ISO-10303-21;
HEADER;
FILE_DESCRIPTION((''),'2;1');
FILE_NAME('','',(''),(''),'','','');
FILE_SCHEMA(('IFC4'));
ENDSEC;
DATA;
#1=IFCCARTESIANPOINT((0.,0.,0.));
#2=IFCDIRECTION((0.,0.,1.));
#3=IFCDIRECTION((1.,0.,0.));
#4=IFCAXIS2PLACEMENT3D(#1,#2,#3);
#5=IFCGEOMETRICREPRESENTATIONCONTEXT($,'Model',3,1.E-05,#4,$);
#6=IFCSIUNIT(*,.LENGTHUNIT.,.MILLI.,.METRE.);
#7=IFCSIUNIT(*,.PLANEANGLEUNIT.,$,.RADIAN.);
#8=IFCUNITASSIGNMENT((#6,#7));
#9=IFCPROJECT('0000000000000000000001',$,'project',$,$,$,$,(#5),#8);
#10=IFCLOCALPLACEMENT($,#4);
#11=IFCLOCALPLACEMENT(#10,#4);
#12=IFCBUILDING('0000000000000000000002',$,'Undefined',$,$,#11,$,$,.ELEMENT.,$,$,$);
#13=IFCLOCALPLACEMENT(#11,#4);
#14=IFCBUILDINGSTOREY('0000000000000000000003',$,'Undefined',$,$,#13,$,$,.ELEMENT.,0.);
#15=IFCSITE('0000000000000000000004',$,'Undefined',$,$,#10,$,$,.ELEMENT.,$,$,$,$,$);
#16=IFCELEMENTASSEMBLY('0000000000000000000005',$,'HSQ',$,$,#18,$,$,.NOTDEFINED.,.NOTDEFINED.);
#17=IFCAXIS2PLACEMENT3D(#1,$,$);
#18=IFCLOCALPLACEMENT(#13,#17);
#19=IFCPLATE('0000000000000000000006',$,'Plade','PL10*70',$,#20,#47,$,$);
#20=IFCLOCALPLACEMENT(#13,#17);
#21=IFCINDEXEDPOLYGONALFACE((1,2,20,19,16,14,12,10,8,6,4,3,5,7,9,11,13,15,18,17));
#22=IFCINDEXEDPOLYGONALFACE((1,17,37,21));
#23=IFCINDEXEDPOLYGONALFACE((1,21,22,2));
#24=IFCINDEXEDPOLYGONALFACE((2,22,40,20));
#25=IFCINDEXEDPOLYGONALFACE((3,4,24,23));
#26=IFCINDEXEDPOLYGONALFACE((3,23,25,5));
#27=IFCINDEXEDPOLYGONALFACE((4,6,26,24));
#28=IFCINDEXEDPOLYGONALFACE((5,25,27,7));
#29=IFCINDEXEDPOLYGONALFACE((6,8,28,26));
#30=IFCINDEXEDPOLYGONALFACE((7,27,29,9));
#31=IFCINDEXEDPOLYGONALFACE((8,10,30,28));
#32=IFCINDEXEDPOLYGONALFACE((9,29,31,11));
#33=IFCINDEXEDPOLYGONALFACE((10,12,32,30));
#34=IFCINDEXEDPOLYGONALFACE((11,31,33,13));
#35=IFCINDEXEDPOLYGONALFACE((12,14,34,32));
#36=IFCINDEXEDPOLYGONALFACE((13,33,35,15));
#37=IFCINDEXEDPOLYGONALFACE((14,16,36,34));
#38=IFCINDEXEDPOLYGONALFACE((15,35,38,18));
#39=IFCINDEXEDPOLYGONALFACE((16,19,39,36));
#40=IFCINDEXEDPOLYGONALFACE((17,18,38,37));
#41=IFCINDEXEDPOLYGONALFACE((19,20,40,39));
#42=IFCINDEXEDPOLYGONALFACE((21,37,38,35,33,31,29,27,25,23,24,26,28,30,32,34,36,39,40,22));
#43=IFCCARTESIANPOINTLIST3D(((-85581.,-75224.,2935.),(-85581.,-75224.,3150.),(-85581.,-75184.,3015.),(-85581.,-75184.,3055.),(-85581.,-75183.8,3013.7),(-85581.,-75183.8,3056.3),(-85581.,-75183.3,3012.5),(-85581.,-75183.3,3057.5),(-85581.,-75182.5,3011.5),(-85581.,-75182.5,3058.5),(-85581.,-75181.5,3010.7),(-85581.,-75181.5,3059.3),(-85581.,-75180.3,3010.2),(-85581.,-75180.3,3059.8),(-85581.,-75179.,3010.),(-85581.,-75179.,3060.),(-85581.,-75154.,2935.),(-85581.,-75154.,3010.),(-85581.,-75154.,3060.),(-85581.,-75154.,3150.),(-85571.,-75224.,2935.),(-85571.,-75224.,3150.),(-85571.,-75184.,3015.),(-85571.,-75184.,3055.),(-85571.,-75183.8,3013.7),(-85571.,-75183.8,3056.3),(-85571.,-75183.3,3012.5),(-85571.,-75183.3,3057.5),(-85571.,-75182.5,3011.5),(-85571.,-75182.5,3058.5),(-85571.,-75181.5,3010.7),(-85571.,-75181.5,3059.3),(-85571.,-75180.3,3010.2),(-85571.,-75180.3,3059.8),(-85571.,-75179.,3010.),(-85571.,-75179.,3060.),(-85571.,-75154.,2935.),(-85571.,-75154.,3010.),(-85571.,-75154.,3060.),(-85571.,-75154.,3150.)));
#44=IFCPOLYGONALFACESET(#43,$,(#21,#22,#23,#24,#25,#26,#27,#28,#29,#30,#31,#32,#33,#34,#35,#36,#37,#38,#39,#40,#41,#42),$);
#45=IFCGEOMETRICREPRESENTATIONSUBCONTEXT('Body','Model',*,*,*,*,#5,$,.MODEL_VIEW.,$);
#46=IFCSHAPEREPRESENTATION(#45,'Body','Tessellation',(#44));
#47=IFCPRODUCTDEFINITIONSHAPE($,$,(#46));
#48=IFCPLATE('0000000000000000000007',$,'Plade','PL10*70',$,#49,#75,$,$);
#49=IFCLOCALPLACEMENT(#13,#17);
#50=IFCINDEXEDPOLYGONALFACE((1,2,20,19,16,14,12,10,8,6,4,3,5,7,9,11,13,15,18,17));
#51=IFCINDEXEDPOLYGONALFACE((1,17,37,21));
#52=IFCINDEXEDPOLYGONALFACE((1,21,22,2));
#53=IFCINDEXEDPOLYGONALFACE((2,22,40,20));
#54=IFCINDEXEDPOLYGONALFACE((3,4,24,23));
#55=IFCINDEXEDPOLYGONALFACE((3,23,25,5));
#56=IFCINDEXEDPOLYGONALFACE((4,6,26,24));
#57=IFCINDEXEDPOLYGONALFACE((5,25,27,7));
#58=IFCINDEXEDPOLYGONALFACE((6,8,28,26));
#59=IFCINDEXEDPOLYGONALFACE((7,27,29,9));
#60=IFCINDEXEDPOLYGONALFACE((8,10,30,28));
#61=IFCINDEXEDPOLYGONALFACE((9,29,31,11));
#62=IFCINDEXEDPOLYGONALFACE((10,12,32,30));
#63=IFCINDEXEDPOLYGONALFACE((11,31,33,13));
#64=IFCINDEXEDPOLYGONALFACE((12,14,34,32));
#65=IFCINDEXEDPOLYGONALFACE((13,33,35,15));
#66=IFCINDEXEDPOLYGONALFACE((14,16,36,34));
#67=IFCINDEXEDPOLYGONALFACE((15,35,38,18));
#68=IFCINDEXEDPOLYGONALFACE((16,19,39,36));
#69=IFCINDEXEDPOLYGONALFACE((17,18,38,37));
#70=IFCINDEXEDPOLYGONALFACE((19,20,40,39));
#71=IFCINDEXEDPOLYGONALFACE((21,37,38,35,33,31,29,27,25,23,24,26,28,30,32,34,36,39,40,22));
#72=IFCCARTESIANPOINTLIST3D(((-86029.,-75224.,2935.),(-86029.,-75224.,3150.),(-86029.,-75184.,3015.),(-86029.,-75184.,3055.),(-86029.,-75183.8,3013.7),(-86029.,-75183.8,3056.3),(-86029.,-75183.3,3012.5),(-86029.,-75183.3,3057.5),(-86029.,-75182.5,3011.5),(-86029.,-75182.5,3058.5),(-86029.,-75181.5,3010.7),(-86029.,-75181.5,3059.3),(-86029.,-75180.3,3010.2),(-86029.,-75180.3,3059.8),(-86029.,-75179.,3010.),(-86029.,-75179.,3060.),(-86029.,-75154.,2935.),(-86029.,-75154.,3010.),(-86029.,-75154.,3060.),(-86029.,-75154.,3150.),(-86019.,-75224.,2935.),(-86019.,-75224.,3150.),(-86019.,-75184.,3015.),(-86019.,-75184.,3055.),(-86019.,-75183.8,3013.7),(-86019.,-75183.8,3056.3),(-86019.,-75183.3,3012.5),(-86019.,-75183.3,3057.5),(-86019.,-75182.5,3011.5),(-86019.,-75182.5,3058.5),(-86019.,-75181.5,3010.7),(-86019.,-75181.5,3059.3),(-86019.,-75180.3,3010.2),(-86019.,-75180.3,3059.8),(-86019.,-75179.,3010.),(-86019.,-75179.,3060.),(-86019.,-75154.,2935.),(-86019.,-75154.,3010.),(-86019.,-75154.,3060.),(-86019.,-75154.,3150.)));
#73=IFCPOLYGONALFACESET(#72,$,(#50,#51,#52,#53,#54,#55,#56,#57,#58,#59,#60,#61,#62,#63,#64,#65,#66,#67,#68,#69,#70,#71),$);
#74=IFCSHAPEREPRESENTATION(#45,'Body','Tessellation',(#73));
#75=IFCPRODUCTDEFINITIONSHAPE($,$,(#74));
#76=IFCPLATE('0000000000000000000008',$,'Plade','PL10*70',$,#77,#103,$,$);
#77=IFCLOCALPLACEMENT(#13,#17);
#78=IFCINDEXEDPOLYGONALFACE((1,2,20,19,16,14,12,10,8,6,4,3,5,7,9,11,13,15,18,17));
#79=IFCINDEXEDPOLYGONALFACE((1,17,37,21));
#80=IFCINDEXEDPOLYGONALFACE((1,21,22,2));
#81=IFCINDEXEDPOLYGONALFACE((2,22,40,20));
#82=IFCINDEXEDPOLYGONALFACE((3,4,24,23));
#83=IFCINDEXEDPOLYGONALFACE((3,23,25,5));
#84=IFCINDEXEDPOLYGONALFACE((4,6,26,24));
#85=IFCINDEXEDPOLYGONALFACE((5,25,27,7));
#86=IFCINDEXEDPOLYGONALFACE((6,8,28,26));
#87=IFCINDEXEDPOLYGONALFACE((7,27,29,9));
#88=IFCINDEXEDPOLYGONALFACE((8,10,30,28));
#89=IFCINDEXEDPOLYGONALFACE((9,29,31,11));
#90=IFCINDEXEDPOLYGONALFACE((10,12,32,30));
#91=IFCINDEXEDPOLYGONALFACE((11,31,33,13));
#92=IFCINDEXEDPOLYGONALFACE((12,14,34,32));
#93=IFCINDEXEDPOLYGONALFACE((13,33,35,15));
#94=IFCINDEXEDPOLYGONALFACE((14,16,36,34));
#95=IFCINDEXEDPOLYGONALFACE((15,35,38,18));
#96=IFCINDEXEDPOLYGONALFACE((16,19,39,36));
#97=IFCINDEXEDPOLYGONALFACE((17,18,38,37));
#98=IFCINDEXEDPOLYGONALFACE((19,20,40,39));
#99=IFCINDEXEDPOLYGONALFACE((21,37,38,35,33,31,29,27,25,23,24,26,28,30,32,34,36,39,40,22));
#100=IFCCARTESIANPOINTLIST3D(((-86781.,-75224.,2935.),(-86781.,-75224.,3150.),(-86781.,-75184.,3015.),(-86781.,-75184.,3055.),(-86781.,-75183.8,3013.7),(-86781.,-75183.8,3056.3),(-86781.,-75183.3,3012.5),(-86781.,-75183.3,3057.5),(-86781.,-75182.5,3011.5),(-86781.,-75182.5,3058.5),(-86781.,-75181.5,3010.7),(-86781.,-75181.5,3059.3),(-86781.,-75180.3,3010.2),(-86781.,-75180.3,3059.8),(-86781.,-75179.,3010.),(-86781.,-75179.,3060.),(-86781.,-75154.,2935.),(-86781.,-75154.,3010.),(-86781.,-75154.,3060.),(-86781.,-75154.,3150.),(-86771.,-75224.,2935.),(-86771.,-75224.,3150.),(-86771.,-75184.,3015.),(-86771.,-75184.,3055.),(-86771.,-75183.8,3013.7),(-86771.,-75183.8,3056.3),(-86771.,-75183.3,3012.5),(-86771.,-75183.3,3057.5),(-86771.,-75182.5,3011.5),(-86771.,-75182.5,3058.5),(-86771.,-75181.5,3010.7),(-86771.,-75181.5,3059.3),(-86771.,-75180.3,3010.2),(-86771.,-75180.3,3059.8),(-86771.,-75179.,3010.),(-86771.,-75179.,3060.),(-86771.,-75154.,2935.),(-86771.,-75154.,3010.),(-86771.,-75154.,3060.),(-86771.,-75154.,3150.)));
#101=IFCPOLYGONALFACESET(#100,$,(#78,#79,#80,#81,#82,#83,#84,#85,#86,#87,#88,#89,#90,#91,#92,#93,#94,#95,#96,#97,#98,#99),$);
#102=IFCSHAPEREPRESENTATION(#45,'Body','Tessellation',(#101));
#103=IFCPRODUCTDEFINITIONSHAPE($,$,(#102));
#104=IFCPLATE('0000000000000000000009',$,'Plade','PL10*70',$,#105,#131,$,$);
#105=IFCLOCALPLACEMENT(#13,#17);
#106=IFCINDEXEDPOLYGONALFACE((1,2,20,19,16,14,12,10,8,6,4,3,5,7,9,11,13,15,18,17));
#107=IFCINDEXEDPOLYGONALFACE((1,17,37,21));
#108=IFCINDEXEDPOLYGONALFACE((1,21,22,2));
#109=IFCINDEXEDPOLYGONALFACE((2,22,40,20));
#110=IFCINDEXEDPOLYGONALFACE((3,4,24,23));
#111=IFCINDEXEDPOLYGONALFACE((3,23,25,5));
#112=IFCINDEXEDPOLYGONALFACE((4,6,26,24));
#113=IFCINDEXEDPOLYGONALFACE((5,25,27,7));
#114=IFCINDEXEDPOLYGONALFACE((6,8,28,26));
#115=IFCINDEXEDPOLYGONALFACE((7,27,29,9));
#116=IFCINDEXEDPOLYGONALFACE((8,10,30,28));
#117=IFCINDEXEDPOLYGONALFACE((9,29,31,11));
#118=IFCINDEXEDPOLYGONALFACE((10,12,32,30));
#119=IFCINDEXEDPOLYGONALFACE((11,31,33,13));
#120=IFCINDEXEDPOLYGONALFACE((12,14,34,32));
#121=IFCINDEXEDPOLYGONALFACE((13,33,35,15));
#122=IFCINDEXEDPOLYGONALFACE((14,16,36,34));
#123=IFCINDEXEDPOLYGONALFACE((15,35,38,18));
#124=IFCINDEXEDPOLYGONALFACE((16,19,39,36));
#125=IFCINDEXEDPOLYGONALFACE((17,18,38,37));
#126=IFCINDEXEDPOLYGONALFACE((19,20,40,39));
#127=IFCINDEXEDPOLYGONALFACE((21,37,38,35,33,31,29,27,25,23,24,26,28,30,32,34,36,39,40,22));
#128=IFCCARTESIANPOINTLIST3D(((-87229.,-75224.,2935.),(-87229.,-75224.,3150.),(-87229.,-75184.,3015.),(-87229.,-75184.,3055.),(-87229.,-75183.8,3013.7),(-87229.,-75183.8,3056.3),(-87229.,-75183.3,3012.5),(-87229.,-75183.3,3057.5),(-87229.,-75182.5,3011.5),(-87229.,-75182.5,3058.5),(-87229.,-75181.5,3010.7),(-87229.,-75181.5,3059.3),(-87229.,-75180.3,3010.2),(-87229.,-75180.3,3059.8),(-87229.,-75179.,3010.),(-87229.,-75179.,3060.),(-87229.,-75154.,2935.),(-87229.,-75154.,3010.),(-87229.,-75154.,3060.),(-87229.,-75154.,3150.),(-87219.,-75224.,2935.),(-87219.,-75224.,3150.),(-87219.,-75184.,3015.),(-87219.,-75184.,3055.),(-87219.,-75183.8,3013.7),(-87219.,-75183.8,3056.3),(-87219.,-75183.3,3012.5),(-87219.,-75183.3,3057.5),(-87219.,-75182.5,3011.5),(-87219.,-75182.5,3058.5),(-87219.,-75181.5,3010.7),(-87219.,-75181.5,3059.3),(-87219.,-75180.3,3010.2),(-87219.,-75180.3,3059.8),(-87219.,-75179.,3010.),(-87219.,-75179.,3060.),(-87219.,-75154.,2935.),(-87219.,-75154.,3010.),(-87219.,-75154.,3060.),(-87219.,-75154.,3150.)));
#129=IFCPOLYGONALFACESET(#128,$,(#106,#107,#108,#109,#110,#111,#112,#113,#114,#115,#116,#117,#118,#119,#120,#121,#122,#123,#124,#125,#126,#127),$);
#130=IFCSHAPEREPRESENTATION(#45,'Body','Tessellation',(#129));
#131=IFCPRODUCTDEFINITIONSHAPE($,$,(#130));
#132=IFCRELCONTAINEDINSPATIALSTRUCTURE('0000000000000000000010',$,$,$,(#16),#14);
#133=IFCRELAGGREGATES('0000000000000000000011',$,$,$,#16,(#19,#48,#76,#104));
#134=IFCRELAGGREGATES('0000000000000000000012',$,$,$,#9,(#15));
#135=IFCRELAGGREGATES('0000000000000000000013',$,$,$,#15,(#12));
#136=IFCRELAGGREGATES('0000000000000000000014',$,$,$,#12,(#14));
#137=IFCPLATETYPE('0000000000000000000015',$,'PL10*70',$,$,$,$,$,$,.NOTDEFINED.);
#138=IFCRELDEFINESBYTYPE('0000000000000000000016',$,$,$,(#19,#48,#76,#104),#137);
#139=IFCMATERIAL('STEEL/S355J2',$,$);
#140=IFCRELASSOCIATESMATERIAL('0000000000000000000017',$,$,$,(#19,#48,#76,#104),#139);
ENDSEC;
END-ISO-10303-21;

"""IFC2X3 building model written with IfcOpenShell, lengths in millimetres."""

from ifc_helpers import new_model, si_unit, frame, frame_2d, origin_with_axes, place, context, subcontext, project, spatial, polyline, circle_curve, parameter, trimmed, segment, composite_curve, outline, extrude, material, type_object, element, aggregate, save


model = new_model("IFC2X3")

# Units and contexts
model_context = context("Model", 3, precision=1e-05, world=origin_with_axes())
body_context = subcontext(model_context, "Body", "Model", "MODEL_VIEW")
ifc_project = project(units=[si_unit("LENGTHUNIT", "METRE", prefix="MILLI"), si_unit("PLANEANGLEUNIT", "RADIAN")], contexts=[model_context])

# Site, building, storey
site_placement = place(None, origin_with_axes())
site = spatial("IfcSite", under=ifc_project, at=site_placement, Name="Undefined", CompositionType="ELEMENT")
building_placement = place(site_placement, origin_with_axes())
building = spatial("IfcBuilding", under=site, at=building_placement, Name="Undefined", CompositionType="ELEMENT")
storey_placement = place(building_placement, origin_with_axes())
storey = spatial("IfcBuildingStorey", under=building, at=storey_placement, Name="Undefined", CompositionType="ELEMENT", Elevation=0.0)

# Element assembly
assembly_1_placement = place(storey_placement, origin_with_axes())
assembly_1 = element("IfcElementAssembly", 1, at=assembly_1_placement, inside=storey, Name="HSQ", AssemblyPlace="NOTDEFINED", PredefinedType="NOTDEFINED")

# Shared definitions
ifc_material_1 = material(Name="STEEL/S355J2")

# Plates
plate_type_1 = type_object("IfcPlateType", Name="PL10*70", PredefinedType="NOTDEFINED")
plate_1_placement = place(assembly_1_placement, frame((-85576.0, -75154.0, 2935.0), z_axis=(-1.0, 0.0, 0.0), x_axis=(0.0, -1.0, 0.0)))
plate_1 = element("IfcPlate", 2, at=plate_1_placement, type_object=plate_type_1, material=ifc_material_1, Name="Plade", Description="PL10*70", context=body_context, shape_type="SweptSolid", body=[
    extrude(outline(composite_curve([segment(polyline([(0.0, 0.0), (70.0, 0.0), (70.0, 215.0), (0.0, 215.0), (0.0, 125.0), (25.0, 125.0)]), True, "CONTINUOUS"), segment(trimmed(circle_curve(frame_2d((25.0, 120.0), x_axis=(0.0, 1.0)), 5.0), [parameter(0.0)], [parameter(4.712389)], False, "PARAMETER"), True, "CONTINUOUS"), segment(polyline([(30.0, 120.0), (30.0, 80.0)]), True, "CONTINUOUS"), segment(trimmed(circle_curve(frame_2d((25.0, 80.0), x_axis=(1.0, 0.0)), 5.0), [parameter(0.0)], [parameter(4.712389)], False, "PARAMETER"), True, "CONTINUOUS"), segment(polyline([(25.0, 75.0), (0.0, 75.0), (0.0, 0.0)]), True, "CONTINUOUS")], self_intersect=True)), frame((0.0, 0.0, -5.0), z_axis=(0.0, 0.0, 1.0), x_axis=(1.0, 0.0, 0.0)), (0.0, 0.0, 1.0), 10.0),
])
plate_2_placement = place(assembly_1_placement, frame((-86024.0, -75154.0, 2935.0), z_axis=(-1.0, 0.0, 0.0), x_axis=(0.0, -1.0, 0.0)))
plate_2 = element("IfcPlate", 3, at=plate_2_placement, type_object=plate_type_1, material=ifc_material_1, Name="Plade", Description="PL10*70", context=body_context, shape_type="SweptSolid", body=[
    extrude(outline(composite_curve([segment(polyline([(0.0, 0.0), (70.0, 0.0), (70.0, 215.0), (0.0, 215.0), (0.0, 125.0), (25.0, 125.0)]), True, "CONTINUOUS"), segment(trimmed(circle_curve(frame_2d((25.0, 120.0), x_axis=(0.0, 1.0)), 5.0), [parameter(0.0)], [parameter(4.712389)], False, "PARAMETER"), True, "CONTINUOUS"), segment(polyline([(30.0, 120.0), (30.0, 80.0)]), True, "CONTINUOUS"), segment(trimmed(circle_curve(frame_2d((25.0, 80.0), x_axis=(1.0, 0.0)), 5.0), [parameter(0.0)], [parameter(4.712389)], False, "PARAMETER"), True, "CONTINUOUS"), segment(polyline([(25.0, 75.0), (0.0, 75.0), (0.0, 0.0)]), True, "CONTINUOUS")], self_intersect=True)), frame((0.0, 0.0, -5.0), z_axis=(0.0, 0.0, 1.0), x_axis=(1.0, 0.0, 0.0)), (0.0, 0.0, 1.0), 10.0),
])
plate_3_placement = place(assembly_1_placement, frame((-86776.0, -75154.0, 2935.0), z_axis=(-1.0, 0.0, 0.0), x_axis=(0.0, -1.0, 0.0)))
plate_3 = element("IfcPlate", 4, at=plate_3_placement, type_object=plate_type_1, material=ifc_material_1, Name="Plade", Description="PL10*70", context=body_context, shape_type="SweptSolid", body=[
    extrude(outline(composite_curve([segment(polyline([(0.0, 0.0), (70.0, 0.0), (70.0, 215.0), (0.0, 215.0), (0.0, 125.0), (25.0, 125.0)]), True, "CONTINUOUS"), segment(trimmed(circle_curve(frame_2d((25.0, 120.0), x_axis=(0.0, 1.0)), 5.0), [parameter(0.0)], [parameter(4.712389)], False, "PARAMETER"), True, "CONTINUOUS"), segment(polyline([(30.0, 120.0), (30.0, 80.0)]), True, "CONTINUOUS"), segment(trimmed(circle_curve(frame_2d((25.0, 80.0), x_axis=(1.0, 0.0)), 5.0), [parameter(0.0)], [parameter(4.712389)], False, "PARAMETER"), True, "CONTINUOUS"), segment(polyline([(25.0, 75.0), (0.0, 75.0), (0.0, 0.0)]), True, "CONTINUOUS")], self_intersect=True)), frame((0.0, 0.0, -5.0), z_axis=(0.0, 0.0, 1.0), x_axis=(1.0, 0.0, 0.0)), (0.0, 0.0, 1.0), 10.0),
])
plate_4_placement = place(assembly_1_placement, frame((-87224.0, -75154.0, 2935.0), z_axis=(-1.0, 0.0, 0.0), x_axis=(0.0, -1.0, 0.0)))
plate_4 = element("IfcPlate", 5, at=plate_4_placement, type_object=plate_type_1, material=ifc_material_1, Name="Plade", Description="PL10*70", context=body_context, shape_type="SweptSolid", body=[
    extrude(outline(composite_curve([segment(polyline([(0.0, 0.0), (70.0, 0.0), (70.0, 215.0), (0.0, 215.0), (0.0, 125.0), (25.0, 125.0)]), True, "CONTINUOUS"), segment(trimmed(circle_curve(frame_2d((25.0, 120.0), x_axis=(0.0, 1.0)), 5.0), [parameter(0.0)], [parameter(4.712389)], False, "PARAMETER"), True, "CONTINUOUS"), segment(polyline([(30.0, 120.0), (30.0, 80.0)]), True, "CONTINUOUS"), segment(trimmed(circle_curve(frame_2d((25.0, 80.0), x_axis=(1.0, 0.0)), 5.0), [parameter(0.0)], [parameter(4.712389)], False, "PARAMETER"), True, "CONTINUOUS"), segment(polyline([(25.0, 75.0), (0.0, 75.0), (0.0, 0.0)]), True, "CONTINUOUS")], self_intersect=True)), frame((0.0, 0.0, -5.0), z_axis=(0.0, 0.0, 1.0), x_axis=(1.0, 0.0, 0.0)), (0.0, 0.0, 1.0), 10.0),
])

aggregate(assembly_1, [plate_1, plate_2, plate_3, plate_4])

save(model, "model.ifc")
